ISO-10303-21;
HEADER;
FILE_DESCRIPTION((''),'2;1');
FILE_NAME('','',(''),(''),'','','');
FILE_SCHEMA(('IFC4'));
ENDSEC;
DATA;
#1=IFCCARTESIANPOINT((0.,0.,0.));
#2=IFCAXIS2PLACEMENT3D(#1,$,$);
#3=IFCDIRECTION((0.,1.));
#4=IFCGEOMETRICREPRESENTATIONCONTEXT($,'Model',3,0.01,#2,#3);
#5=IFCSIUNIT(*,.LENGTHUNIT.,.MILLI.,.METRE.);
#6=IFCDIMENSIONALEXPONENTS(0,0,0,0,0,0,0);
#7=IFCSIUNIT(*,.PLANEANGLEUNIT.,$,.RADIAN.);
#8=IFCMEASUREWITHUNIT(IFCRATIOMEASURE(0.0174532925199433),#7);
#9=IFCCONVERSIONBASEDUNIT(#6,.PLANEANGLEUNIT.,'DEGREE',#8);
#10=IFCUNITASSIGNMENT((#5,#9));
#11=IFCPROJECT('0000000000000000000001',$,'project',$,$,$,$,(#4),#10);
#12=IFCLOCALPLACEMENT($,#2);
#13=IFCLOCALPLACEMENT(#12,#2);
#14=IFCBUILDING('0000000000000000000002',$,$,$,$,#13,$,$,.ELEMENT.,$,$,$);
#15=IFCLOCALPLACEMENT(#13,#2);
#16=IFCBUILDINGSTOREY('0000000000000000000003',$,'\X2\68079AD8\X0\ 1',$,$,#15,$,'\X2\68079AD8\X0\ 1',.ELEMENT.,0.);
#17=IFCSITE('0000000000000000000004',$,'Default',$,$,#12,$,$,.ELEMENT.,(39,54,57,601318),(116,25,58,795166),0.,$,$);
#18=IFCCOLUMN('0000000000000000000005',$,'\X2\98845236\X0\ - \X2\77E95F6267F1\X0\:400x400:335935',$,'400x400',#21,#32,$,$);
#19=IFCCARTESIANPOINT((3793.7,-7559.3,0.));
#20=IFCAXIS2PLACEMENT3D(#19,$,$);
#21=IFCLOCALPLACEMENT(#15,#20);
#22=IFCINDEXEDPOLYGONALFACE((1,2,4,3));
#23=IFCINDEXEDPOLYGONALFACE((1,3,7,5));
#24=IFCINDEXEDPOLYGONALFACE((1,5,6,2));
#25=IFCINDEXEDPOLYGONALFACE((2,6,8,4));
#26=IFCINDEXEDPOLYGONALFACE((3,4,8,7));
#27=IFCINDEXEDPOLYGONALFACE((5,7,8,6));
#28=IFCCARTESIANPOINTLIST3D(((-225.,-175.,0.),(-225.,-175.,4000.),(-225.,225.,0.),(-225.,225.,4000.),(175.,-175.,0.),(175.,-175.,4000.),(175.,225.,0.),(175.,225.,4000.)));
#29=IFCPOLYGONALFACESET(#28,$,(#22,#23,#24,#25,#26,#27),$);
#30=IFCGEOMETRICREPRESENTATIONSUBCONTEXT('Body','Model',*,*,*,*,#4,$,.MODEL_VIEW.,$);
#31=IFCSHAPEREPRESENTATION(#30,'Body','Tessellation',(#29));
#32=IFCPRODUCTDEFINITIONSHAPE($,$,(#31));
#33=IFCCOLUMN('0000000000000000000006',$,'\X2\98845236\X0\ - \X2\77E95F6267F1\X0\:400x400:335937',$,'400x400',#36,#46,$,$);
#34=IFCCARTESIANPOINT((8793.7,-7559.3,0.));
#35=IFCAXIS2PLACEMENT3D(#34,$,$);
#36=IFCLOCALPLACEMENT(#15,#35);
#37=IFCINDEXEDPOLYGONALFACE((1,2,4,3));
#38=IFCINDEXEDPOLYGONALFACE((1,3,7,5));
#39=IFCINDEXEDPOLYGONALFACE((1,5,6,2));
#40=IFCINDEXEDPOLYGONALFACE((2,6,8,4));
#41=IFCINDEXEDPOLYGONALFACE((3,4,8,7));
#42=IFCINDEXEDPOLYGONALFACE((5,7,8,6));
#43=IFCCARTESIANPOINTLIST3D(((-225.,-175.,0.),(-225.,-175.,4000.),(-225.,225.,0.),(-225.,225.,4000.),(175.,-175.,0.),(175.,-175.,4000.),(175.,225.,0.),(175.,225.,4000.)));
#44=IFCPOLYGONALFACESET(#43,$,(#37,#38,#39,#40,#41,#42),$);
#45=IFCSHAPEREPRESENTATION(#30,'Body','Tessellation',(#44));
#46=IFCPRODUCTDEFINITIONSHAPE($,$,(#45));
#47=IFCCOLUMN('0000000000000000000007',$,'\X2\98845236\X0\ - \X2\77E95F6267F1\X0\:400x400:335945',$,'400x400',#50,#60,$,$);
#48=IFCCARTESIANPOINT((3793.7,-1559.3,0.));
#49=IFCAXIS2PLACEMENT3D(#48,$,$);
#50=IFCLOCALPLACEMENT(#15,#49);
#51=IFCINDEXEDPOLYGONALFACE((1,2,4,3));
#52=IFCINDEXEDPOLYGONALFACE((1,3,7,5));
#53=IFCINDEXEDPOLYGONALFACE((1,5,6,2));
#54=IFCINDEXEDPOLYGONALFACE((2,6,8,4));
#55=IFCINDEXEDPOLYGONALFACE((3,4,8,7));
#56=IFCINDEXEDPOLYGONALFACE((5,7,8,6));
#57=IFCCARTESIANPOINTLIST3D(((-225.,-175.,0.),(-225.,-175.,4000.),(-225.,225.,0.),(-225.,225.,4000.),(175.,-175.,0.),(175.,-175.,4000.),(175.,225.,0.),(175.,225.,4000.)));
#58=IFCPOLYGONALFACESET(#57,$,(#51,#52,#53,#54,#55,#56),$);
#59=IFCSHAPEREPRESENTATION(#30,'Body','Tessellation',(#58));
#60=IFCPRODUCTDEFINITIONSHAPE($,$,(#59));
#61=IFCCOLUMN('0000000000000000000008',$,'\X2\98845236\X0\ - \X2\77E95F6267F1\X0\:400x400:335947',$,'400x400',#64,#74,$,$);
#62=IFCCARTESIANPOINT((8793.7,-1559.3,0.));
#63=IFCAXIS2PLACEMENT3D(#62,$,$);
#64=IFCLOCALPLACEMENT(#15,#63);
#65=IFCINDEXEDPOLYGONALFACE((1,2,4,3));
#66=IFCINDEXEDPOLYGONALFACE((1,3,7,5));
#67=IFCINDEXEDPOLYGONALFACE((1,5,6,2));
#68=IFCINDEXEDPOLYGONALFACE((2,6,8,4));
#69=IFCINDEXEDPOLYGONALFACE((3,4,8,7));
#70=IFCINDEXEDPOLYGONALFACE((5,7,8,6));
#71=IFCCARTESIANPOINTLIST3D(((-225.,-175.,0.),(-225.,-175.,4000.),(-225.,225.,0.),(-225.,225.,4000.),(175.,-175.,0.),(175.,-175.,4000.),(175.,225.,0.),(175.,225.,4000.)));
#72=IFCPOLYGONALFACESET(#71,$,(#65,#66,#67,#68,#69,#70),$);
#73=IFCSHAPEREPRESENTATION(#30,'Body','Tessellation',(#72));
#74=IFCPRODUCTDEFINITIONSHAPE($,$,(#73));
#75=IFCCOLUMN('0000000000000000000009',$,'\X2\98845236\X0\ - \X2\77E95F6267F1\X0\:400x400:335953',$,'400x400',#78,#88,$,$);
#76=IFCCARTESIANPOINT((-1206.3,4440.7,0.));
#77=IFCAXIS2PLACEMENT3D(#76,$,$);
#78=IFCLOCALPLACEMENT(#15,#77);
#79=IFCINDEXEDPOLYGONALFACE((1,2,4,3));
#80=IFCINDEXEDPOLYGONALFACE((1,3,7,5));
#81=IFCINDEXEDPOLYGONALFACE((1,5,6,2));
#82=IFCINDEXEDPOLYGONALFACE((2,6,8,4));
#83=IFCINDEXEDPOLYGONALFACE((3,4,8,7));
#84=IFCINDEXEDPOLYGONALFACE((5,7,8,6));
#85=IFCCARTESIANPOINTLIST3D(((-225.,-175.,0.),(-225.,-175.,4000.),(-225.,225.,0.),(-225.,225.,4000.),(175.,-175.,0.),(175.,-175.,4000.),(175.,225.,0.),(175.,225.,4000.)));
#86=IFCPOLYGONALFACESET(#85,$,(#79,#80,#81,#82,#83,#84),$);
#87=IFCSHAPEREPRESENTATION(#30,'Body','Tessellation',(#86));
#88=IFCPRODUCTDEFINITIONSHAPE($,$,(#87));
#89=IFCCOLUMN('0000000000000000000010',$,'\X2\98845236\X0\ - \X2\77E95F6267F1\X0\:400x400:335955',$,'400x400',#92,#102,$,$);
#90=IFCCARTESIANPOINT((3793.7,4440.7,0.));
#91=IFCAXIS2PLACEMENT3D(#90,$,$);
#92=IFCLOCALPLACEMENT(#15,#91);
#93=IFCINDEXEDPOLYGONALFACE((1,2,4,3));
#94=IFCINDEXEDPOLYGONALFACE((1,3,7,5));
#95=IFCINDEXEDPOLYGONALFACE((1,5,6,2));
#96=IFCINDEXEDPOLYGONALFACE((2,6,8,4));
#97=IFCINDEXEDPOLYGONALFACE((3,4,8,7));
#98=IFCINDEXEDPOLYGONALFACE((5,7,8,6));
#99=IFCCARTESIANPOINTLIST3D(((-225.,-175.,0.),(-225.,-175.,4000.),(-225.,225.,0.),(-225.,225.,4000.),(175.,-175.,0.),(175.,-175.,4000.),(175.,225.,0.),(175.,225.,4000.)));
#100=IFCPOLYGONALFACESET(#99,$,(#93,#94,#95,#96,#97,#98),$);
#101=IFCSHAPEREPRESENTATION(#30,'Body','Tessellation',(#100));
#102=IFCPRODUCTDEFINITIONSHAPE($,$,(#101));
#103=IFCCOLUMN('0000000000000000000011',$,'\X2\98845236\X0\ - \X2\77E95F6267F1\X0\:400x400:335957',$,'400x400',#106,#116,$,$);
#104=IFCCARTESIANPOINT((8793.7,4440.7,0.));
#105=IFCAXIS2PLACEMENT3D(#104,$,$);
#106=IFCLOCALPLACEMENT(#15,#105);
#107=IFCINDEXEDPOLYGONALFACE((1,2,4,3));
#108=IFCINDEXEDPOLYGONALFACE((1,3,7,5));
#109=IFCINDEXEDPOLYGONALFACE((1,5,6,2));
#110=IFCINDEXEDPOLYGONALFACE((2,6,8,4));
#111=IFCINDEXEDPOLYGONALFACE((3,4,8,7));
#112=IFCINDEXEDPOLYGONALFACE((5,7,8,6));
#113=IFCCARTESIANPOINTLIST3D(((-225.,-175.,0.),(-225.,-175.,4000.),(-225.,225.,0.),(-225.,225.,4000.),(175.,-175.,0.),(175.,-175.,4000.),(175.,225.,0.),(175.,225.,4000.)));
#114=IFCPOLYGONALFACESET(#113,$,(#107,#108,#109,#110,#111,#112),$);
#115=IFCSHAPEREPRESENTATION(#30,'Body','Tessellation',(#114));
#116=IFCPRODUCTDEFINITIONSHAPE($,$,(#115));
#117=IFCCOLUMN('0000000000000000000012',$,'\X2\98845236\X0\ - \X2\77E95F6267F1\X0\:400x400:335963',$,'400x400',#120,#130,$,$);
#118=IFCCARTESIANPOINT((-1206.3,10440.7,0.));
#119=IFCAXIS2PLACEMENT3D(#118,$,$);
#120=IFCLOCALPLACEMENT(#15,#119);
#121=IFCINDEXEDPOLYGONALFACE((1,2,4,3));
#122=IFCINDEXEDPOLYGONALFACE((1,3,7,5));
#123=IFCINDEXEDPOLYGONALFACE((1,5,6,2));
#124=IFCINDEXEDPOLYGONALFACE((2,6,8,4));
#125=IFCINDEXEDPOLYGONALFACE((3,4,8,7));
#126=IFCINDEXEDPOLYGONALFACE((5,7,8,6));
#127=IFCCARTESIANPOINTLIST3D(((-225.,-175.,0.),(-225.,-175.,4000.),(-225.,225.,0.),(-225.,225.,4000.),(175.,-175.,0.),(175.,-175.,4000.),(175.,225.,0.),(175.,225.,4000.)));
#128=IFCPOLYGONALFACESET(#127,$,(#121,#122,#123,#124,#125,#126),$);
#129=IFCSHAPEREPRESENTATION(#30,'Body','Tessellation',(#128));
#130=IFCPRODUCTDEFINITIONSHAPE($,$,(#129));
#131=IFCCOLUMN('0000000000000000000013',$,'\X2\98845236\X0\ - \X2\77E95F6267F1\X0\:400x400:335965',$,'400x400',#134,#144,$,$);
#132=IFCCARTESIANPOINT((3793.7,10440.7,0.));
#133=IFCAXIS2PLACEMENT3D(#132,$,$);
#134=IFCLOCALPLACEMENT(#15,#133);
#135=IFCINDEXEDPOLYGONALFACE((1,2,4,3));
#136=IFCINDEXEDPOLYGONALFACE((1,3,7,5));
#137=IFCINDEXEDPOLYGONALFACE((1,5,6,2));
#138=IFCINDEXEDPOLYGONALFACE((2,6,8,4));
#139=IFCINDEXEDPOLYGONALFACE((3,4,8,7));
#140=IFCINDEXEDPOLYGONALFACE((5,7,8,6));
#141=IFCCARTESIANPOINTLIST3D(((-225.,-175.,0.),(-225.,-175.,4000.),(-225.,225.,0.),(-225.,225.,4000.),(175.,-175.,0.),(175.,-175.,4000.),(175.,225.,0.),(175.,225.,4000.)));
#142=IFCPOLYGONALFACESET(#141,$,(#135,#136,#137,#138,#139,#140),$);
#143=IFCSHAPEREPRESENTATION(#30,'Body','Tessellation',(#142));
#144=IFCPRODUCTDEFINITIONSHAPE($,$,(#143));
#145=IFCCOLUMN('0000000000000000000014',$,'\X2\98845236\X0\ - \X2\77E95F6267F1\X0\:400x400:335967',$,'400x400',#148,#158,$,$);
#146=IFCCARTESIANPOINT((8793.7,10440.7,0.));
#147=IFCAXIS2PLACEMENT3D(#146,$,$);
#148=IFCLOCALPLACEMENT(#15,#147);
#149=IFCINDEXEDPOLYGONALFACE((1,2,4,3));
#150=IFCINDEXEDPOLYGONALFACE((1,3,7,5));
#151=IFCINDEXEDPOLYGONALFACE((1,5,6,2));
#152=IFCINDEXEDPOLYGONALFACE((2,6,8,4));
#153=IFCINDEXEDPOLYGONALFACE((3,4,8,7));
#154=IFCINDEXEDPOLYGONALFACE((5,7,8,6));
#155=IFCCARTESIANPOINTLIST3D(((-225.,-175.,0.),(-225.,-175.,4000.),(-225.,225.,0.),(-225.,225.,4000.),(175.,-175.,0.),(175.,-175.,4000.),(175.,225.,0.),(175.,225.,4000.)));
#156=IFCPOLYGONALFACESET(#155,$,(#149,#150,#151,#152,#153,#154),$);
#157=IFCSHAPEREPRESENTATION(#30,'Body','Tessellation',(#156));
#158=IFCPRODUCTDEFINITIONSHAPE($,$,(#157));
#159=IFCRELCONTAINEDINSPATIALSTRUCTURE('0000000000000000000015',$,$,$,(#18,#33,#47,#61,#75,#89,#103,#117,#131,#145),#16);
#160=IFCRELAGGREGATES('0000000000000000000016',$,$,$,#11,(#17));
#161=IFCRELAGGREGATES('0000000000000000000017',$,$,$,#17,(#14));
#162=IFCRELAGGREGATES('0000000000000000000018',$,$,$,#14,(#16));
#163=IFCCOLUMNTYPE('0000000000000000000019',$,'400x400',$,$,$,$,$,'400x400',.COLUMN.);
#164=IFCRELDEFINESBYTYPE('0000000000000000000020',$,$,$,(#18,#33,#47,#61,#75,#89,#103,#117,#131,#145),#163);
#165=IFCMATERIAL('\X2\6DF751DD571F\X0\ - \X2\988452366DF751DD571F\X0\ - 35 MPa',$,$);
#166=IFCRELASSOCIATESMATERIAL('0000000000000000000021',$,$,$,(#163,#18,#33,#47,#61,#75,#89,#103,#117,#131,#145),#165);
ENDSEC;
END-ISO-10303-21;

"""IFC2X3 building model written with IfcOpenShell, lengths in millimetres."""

from ifc_helpers import new_model, entity, si_unit, converted_unit, direction, frame, frame_2d, origin, place, context, subcontext, project, spatial, rectangle, extrude, source, transform, mapped, material, type_object, type_shapes, element, save


model = new_model("IFC2X3")

# Units and contexts
model_context = context("Model", 3, precision=0.01, world=origin(), true_north=direction((0.0, 1.0)))
body_context = subcontext(model_context, "Body", "Model", "MODEL_VIEW")
ifc_project = project(units=[si_unit("LENGTHUNIT", "METRE", prefix="MILLI"), converted_unit("PLANEANGLEUNIT", "DEGREE", entity("IfcRatioMeasure", 0.0174532925199433), si_unit("PLANEANGLEUNIT", "RADIAN"), dimensions=[0, 0, 0, 0, 0, 0, 0])], contexts=[model_context])

# Site, building, storey
site_placement = place(None, origin())
site = spatial("IfcSite", under=ifc_project, at=site_placement, Name="Default", CompositionType="ELEMENT", RefLatitude=(39, 54, 57, 601318), RefLongitude=(116, 25, 58, 795166), RefElevation=0.0)
building_placement = place(site_placement, origin())
building = spatial("IfcBuilding", under=site, at=building_placement, CompositionType="ELEMENT")
storey_placement = place(building_placement, origin())
storey = spatial("IfcBuildingStorey", under=building, at=storey_placement, Name="标高 1", LongName="标高 1", CompositionType="ELEMENT", Elevation=0.0)

# Columns
ifc_material_1 = material(Name="混凝土 - 预制混凝土 - 35 MPa")
column_type = type_object("IfcColumnType", Name="400x400", ElementType="400x400", PredefinedType="COLUMN", material=ifc_material_1)
shared_shape_1 = source(origin(), body_context, "Body", "SweptSolid", [
    extrude(rectangle(XDim=400.0, YDim=400.0, at=frame_2d((0.0, 0.0), x_axis=(1.0, 0.0))), frame((-25.0, 25.0, 0.0)), (0.0, 0.0, 1.0), 4000.0),
])
type_shapes(column_type, [shared_shape_1])
for number, where, name in (
    (1, (3793.7, -7559.3, 0.0), "预制 - 矩形柱:400x400:335935"),
    (2, (8793.7, -7559.3, 0.0), "预制 - 矩形柱:400x400:335937"),
    (3, (3793.7, -1559.3, 0.0), "预制 - 矩形柱:400x400:335945"),
    (4, (8793.7, -1559.3, 0.0), "预制 - 矩形柱:400x400:335947"),
    (5, (-1206.3, 4440.7, 0.0), "预制 - 矩形柱:400x400:335953"),
    (6, (3793.7, 4440.7, 0.0), "预制 - 矩形柱:400x400:335955"),
    (7, (8793.7, 4440.7, 0.0), "预制 - 矩形柱:400x400:335957"),
    (8, (-1206.3, 10440.7, 0.0), "预制 - 矩形柱:400x400:335963"),
    (9, (3793.7, 10440.7, 0.0), "预制 - 矩形柱:400x400:335965"),
    (10, (8793.7, 10440.7, 0.0), "预制 - 矩形柱:400x400:335967"),
):
    element("IfcColumn", number, at=place(storey_placement, frame(where)), inside=storey, type_object=column_type, material=ifc_material_1, Name=name, ObjectType="400x400", context=body_context, shape_type="MappedRepresentation", body=[
        mapped(shared_shape_1, transform((0.0, 0.0, 0.0), scale=1.0)),
    ])

save(model, "model.ifc")
